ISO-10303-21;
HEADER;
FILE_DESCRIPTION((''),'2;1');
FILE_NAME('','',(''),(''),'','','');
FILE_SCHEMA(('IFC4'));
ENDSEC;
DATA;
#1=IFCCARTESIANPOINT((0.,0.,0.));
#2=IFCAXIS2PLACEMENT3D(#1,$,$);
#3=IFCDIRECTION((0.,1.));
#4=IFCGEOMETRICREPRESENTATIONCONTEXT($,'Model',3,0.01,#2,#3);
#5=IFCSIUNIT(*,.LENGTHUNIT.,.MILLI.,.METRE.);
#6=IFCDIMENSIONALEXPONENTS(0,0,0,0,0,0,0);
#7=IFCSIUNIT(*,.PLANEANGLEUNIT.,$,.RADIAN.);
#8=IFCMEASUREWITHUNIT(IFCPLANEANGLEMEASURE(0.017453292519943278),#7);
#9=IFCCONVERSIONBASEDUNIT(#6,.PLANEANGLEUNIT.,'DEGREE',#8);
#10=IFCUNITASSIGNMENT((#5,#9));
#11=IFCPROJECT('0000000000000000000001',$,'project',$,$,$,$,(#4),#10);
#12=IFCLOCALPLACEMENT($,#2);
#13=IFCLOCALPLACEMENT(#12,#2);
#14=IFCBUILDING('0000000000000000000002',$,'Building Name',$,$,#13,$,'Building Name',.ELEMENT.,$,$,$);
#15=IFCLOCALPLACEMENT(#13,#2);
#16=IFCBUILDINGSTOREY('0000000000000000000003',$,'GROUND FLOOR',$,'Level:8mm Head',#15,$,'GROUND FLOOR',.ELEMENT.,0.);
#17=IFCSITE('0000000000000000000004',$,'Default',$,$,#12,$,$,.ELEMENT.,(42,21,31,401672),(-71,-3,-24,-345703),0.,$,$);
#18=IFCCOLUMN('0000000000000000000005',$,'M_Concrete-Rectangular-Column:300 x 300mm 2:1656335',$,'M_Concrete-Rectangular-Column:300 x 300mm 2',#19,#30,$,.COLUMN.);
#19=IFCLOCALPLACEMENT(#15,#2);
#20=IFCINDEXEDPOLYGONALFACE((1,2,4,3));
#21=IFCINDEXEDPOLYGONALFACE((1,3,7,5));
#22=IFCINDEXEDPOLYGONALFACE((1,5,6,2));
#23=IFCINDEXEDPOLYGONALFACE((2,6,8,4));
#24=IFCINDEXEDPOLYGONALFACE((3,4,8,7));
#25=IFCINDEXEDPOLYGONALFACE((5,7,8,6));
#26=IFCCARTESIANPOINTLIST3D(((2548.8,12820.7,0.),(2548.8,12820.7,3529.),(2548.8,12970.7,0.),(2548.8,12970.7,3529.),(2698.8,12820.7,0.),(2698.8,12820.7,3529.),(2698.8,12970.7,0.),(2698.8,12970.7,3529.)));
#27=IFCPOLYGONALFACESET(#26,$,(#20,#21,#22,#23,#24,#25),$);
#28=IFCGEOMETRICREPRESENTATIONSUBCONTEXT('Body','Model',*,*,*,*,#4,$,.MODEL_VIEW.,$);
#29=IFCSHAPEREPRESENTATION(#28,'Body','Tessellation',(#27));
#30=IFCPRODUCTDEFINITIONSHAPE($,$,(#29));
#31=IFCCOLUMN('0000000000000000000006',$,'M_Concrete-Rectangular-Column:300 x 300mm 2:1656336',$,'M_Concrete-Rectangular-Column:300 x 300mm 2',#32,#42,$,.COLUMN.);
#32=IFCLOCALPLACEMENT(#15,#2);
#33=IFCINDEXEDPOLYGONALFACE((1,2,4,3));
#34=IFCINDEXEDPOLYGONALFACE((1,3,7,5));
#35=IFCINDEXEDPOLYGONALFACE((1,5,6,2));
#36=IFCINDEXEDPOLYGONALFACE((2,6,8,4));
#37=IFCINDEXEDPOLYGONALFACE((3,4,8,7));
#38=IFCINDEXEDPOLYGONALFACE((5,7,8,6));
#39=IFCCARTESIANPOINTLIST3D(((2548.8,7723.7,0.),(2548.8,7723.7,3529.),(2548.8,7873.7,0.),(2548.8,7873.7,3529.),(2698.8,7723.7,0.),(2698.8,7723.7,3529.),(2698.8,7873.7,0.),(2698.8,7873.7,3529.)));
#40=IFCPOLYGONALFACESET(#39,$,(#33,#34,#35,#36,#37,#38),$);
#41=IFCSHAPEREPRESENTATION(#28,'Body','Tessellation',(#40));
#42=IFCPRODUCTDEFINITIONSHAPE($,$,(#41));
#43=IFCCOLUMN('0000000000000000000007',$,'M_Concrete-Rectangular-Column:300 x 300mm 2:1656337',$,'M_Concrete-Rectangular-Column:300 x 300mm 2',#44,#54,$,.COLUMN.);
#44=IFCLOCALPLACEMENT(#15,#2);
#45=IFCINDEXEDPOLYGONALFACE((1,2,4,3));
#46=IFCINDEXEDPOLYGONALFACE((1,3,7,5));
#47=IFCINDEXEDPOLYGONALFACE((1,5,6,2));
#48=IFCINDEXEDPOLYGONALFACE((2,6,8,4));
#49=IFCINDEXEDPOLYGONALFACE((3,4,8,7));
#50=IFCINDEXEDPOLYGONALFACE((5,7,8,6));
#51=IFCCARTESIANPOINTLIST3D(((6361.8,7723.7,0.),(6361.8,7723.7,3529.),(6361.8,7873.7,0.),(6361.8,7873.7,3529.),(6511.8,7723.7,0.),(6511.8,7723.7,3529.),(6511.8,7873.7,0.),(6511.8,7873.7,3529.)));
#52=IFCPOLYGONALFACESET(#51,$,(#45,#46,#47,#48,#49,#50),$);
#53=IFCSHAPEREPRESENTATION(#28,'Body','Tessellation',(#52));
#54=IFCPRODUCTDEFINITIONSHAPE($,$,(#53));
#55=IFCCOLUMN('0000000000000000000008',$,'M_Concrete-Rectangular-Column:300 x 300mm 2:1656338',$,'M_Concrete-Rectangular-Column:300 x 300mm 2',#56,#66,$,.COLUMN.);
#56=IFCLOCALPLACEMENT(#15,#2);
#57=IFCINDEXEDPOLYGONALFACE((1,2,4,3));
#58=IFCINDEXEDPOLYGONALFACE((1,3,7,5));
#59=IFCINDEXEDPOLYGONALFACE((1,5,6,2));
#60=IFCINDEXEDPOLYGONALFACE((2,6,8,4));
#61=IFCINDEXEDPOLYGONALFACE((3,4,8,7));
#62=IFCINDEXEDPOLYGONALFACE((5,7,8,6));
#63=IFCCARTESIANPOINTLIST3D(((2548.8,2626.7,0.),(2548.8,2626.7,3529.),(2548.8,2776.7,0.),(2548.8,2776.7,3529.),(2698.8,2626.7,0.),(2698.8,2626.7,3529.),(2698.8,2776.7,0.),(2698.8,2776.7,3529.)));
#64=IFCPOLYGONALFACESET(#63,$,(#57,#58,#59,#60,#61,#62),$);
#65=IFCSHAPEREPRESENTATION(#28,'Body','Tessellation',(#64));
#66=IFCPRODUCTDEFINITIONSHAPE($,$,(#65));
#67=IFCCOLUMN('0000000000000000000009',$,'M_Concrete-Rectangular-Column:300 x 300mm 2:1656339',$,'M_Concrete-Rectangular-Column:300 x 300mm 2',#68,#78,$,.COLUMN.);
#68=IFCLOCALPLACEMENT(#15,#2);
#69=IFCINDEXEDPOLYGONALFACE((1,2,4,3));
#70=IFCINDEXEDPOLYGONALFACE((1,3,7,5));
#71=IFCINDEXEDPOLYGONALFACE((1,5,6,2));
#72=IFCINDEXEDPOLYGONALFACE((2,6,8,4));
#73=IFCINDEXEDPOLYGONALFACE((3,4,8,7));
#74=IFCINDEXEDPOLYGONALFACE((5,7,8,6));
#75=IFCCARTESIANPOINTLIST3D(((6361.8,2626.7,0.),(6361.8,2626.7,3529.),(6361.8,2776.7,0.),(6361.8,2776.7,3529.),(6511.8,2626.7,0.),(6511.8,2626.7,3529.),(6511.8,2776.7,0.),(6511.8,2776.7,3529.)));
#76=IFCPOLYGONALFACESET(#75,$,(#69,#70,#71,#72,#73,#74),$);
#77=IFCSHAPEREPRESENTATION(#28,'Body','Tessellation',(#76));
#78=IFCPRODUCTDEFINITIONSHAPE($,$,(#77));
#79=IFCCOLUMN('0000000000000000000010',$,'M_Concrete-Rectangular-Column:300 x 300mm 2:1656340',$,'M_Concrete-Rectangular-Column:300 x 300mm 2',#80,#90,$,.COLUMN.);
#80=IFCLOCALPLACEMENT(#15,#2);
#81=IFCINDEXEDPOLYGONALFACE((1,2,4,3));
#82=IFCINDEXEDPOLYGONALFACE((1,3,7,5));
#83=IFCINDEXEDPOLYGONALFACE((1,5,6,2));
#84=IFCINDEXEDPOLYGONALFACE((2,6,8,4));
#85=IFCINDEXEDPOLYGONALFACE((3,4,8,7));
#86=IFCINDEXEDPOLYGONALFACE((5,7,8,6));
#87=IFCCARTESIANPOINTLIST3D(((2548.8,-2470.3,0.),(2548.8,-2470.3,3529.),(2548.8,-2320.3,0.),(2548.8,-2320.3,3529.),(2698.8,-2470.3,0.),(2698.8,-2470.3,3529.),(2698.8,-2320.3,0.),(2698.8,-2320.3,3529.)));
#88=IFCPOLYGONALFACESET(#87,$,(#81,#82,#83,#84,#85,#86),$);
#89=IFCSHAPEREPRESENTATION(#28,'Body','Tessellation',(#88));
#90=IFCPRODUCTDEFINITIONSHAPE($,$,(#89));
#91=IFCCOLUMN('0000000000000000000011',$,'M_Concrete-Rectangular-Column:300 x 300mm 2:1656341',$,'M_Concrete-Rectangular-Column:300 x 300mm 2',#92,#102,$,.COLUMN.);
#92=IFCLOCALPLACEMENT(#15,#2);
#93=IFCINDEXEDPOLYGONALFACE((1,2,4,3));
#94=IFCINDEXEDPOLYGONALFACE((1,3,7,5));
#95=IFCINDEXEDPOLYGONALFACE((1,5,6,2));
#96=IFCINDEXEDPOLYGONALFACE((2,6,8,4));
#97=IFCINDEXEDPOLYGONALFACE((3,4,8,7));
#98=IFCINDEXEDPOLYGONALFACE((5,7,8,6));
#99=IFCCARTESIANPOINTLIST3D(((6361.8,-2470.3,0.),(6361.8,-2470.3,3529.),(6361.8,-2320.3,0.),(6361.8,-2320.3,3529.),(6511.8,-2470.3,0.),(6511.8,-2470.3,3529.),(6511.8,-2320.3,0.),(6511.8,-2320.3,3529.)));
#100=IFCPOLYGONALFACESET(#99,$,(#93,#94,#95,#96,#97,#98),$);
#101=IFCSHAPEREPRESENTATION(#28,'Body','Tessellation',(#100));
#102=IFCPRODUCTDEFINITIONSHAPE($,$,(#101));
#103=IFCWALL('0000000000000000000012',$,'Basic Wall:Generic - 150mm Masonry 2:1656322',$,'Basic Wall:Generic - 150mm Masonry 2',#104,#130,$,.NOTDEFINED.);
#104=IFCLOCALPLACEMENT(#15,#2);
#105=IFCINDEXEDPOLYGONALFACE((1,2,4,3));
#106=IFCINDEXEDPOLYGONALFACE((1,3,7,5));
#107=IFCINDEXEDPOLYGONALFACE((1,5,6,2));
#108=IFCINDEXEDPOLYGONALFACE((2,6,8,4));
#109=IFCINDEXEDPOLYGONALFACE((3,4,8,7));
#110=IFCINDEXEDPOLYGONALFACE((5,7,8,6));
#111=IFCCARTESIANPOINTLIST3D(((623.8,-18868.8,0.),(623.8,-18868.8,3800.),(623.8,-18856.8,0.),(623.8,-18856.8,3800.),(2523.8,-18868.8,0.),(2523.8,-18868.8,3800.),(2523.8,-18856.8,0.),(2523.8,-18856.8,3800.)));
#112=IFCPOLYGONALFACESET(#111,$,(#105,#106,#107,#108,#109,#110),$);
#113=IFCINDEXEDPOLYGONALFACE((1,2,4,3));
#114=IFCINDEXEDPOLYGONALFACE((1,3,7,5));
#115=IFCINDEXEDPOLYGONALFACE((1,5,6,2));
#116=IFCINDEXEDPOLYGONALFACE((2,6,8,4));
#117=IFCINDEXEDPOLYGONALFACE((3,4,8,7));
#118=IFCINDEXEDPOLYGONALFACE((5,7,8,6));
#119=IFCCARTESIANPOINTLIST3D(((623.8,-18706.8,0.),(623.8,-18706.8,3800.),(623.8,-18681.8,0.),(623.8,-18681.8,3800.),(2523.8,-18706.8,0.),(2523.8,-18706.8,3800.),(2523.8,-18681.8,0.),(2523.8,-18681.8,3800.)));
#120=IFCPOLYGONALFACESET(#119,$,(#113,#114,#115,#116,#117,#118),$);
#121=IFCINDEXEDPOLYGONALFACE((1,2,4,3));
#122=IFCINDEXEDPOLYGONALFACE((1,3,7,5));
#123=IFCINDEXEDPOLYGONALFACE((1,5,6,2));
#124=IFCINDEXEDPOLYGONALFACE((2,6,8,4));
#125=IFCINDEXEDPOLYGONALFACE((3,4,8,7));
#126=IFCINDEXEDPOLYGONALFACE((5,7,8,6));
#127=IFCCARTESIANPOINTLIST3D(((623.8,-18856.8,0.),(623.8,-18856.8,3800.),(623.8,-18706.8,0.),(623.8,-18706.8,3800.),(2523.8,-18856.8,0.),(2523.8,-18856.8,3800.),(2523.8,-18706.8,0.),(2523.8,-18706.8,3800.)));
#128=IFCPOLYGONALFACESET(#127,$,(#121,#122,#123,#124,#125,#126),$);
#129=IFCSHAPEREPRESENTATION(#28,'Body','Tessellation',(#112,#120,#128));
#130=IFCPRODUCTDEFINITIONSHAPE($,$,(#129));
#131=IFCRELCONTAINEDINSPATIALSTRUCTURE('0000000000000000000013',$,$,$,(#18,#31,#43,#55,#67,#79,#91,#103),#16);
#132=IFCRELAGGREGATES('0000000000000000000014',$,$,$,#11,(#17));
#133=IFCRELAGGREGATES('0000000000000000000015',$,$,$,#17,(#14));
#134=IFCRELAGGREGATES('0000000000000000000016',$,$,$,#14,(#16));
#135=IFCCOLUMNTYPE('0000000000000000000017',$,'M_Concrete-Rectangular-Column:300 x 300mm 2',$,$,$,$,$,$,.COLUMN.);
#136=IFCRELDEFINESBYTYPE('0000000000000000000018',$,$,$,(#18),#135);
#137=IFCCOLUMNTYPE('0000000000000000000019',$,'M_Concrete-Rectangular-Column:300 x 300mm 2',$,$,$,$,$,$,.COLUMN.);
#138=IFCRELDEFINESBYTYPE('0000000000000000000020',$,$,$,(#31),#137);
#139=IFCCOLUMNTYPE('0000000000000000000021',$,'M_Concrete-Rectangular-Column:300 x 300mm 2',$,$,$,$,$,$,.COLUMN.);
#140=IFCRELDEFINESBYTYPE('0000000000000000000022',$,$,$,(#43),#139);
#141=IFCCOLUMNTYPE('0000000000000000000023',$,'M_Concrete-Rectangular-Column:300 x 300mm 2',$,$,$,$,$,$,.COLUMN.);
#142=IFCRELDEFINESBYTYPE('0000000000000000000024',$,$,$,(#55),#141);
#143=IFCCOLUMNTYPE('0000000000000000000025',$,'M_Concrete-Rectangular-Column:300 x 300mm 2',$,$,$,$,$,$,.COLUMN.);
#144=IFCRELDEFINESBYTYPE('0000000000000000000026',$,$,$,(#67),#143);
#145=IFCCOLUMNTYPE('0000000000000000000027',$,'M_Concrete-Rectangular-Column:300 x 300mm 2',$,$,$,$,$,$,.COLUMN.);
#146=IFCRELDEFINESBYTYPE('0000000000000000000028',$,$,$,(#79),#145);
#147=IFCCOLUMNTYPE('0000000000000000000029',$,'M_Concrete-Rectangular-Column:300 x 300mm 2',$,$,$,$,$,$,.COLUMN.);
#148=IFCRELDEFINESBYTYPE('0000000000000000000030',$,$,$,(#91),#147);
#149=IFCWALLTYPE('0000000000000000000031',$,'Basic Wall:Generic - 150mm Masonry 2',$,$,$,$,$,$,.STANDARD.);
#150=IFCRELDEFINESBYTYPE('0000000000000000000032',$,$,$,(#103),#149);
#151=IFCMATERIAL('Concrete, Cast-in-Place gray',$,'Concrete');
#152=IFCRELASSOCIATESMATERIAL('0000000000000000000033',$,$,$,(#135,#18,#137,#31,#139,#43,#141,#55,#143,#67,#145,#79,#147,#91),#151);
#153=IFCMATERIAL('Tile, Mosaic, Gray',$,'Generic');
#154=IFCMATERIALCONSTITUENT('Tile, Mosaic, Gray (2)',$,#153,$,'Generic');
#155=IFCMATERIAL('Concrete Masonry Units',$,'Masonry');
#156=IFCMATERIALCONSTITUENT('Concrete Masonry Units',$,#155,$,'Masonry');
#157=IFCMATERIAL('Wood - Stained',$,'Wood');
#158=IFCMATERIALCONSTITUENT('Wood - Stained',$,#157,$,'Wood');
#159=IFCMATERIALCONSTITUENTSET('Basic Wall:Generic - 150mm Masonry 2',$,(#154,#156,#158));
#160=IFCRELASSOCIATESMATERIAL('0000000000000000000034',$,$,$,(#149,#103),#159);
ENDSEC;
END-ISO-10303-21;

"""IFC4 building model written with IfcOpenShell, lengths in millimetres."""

from ifc_helpers import new_model, entity, si_unit, converted_unit, direction, frame, origin, place, context, subcontext, project, spatial, indexed_curve, outline, extrude, source, transform, mapped, material, constituent, constituent_set, type_object, type_shapes, element, save


model = new_model("IFC4")

# Units and contexts
model_context = context("Model", 3, precision=0.01, world=origin(), true_north=direction((0.0, 1.0)))
body_context = subcontext(model_context, "Body", "Model", "MODEL_VIEW")
ifc_project = project(units=[si_unit("LENGTHUNIT", "METRE", prefix="MILLI"), converted_unit("PLANEANGLEUNIT", "DEGREE", entity("IfcPlaneAngleMeasure", 0.017453292519943278), si_unit("PLANEANGLEUNIT", "RADIAN"), dimensions=[0, 0, 0, 0, 0, 0, 0])], contexts=[model_context])

# Site, building, storey
site_placement = place(None, origin())
site = spatial("IfcSite", under=ifc_project, at=site_placement, Name="Default", CompositionType="ELEMENT", RefLatitude=(42, 21, 31, 401672), RefLongitude=(-71, -3, -24, -345703), RefElevation=0.0)
building_placement = place(site_placement, origin())
building = spatial("IfcBuilding", under=site, at=building_placement, Name="Building Name", LongName="Building Name", CompositionType="ELEMENT")
storey_placement = place(building_placement, origin())
storey = spatial("IfcBuildingStorey", under=building, at=storey_placement, Name="GROUND FLOOR", ObjectType="Level:8mm Head", LongName="GROUND FLOOR", CompositionType="ELEMENT", Elevation=0.0)

# Columns
ifc_material_1 = material(Name="Concrete, Cast-in-Place gray", Category="Concrete")
column_type_1 = type_object("IfcColumnType", Name="M_Concrete-Rectangular-Column:300 x 300mm 2", PredefinedType="COLUMN", material=ifc_material_1)
shared_shape_1 = source(origin(), body_context, "Body", "SweptSolid", [
    extrude(outline(indexed_curve([(-75.0, -75.0), (75.0, -75.0), (75.0, 75.0), (-75.0, 75.0), (-75.0, -75.0)], self_intersect=False)), frame((2623.8, 12895.7, 0.0)), (0.0, 0.0, 1.0), 3529.0),
])
type_shapes(column_type_1, [shared_shape_1])
column_1_placement = place(storey_placement, origin())
element("IfcColumn", 1, at=column_1_placement, inside=storey, type_object=column_type_1, material=ifc_material_1, Name="M_Concrete-Rectangular-Column:300 x 300mm 2:1656335", ObjectType="M_Concrete-Rectangular-Column:300 x 300mm 2", PredefinedType="COLUMN", context=body_context, shape_type="MappedRepresentation", body=[
    mapped(shared_shape_1, transform((0.0, 0.0, 0.0), scale=1.0)),
])
column_type_2 = type_object("IfcColumnType", Name="M_Concrete-Rectangular-Column:300 x 300mm 2", PredefinedType="COLUMN", material=ifc_material_1)
shared_shape_2 = source(origin(), body_context, "Body", "SweptSolid", [
    extrude(outline(indexed_curve([(-75.0, -75.0), (75.0, -75.0), (75.0, 75.0), (-75.0, 75.0), (-75.0, -75.0)], self_intersect=False)), frame((2623.8, 7798.7, 0.0)), (0.0, 0.0, 1.0), 3529.0),
])
type_shapes(column_type_2, [shared_shape_2])
column_2_placement = place(storey_placement, origin())
element("IfcColumn", 2, at=column_2_placement, inside=storey, type_object=column_type_2, material=ifc_material_1, Name="M_Concrete-Rectangular-Column:300 x 300mm 2:1656336", ObjectType="M_Concrete-Rectangular-Column:300 x 300mm 2", PredefinedType="COLUMN", context=body_context, shape_type="MappedRepresentation", body=[
    mapped(shared_shape_2, transform((0.0, 0.0, 0.0), scale=1.0)),
])
column_type_3 = type_object("IfcColumnType", Name="M_Concrete-Rectangular-Column:300 x 300mm 2", PredefinedType="COLUMN", material=ifc_material_1)
shared_shape_3 = source(origin(), body_context, "Body", "SweptSolid", [
    extrude(outline(indexed_curve([(-75.0, -75.0), (75.0, -75.0), (75.0, 75.0), (-75.0, 75.0), (-75.0, -75.0)], self_intersect=False)), frame((6436.8, 7798.7, 0.0)), (0.0, 0.0, 1.0), 3529.0),
])
type_shapes(column_type_3, [shared_shape_3])
column_3_placement = place(storey_placement, origin())
element("IfcColumn", 3, at=column_3_placement, inside=storey, type_object=column_type_3, material=ifc_material_1, Name="M_Concrete-Rectangular-Column:300 x 300mm 2:1656337", ObjectType="M_Concrete-Rectangular-Column:300 x 300mm 2", PredefinedType="COLUMN", context=body_context, shape_type="MappedRepresentation", body=[
    mapped(shared_shape_3, transform((0.0, 0.0, 0.0), scale=1.0)),
])
column_type_4 = type_object("IfcColumnType", Name="M_Concrete-Rectangular-Column:300 x 300mm 2", PredefinedType="COLUMN", material=ifc_material_1)
shared_shape_4 = source(origin(), body_context, "Body", "SweptSolid", [
    extrude(outline(indexed_curve([(-75.0, -75.0), (75.0, -75.0), (75.0, 75.0), (-75.0, 75.0), (-75.0, -75.0)], self_intersect=False)), frame((2623.8, 2701.7, 0.0)), (0.0, 0.0, 1.0), 3529.0),
])
type_shapes(column_type_4, [shared_shape_4])
column_4_placement = place(storey_placement, origin())
element("IfcColumn", 4, at=column_4_placement, inside=storey, type_object=column_type_4, material=ifc_material_1, Name="M_Concrete-Rectangular-Column:300 x 300mm 2:1656338", ObjectType="M_Concrete-Rectangular-Column:300 x 300mm 2", PredefinedType="COLUMN", context=body_context, shape_type="MappedRepresentation", body=[
    mapped(shared_shape_4, transform((0.0, 0.0, 0.0), scale=1.0)),
])
column_type_5 = type_object("IfcColumnType", Name="M_Concrete-Rectangular-Column:300 x 300mm 2", PredefinedType="COLUMN", material=ifc_material_1)
shared_shape_5 = source(origin(), body_context, "Body", "SweptSolid", [
    extrude(outline(indexed_curve([(-75.0, -75.0), (75.0, -75.0), (75.0, 75.0), (-75.0, 75.0), (-75.0, -75.0)], self_intersect=False)), frame((6436.8, 2701.7, 0.0)), (0.0, 0.0, 1.0), 3529.0),
])
type_shapes(column_type_5, [shared_shape_5])
column_5_placement = place(storey_placement, origin())
element("IfcColumn", 5, at=column_5_placement, inside=storey, type_object=column_type_5, material=ifc_material_1, Name="M_Concrete-Rectangular-Column:300 x 300mm 2:1656339", ObjectType="M_Concrete-Rectangular-Column:300 x 300mm 2", PredefinedType="COLUMN", context=body_context, shape_type="MappedRepresentation", body=[
    mapped(shared_shape_5, transform((0.0, 0.0, 0.0), scale=1.0)),
])
column_type_6 = type_object("IfcColumnType", Name="M_Concrete-Rectangular-Column:300 x 300mm 2", PredefinedType="COLUMN", material=ifc_material_1)
shared_shape_6 = source(origin(), body_context, "Body", "SweptSolid", [
    extrude(outline(indexed_curve([(-75.0, -75.0), (75.0, -75.0), (75.0, 75.0), (-75.0, 75.0), (-75.0, -75.0)], self_intersect=False)), frame((2623.8, -2395.3, 0.0)), (0.0, 0.0, 1.0), 3529.0),
])
type_shapes(column_type_6, [shared_shape_6])
column_6_placement = place(storey_placement, origin())
element("IfcColumn", 6, at=column_6_placement, inside=storey, type_object=column_type_6, material=ifc_material_1, Name="M_Concrete-Rectangular-Column:300 x 300mm 2:1656340", ObjectType="M_Concrete-Rectangular-Column:300 x 300mm 2", PredefinedType="COLUMN", context=body_context, shape_type="MappedRepresentation", body=[
    mapped(shared_shape_6, transform((0.0, 0.0, 0.0), scale=1.0)),
])
column_type_7 = type_object("IfcColumnType", Name="M_Concrete-Rectangular-Column:300 x 300mm 2", PredefinedType="COLUMN", material=ifc_material_1)
shared_shape_7 = source(origin(), body_context, "Body", "SweptSolid", [
    extrude(outline(indexed_curve([(-75.0, -75.0), (75.0, -75.0), (75.0, 75.0), (-75.0, 75.0), (-75.0, -75.0)], self_intersect=False)), frame((6436.8, -2395.3, 0.0)), (0.0, 0.0, 1.0), 3529.0),
])
type_shapes(column_type_7, [shared_shape_7])
column_7_placement = place(storey_placement, origin())
element("IfcColumn", 7, at=column_7_placement, inside=storey, type_object=column_type_7, material=ifc_material_1, Name="M_Concrete-Rectangular-Column:300 x 300mm 2:1656341", ObjectType="M_Concrete-Rectangular-Column:300 x 300mm 2", PredefinedType="COLUMN", context=body_context, shape_type="MappedRepresentation", body=[
    mapped(shared_shape_7, transform((0.0, 0.0, 0.0), scale=1.0)),
])

# Wall
ifc_material_2 = material(Name="Tile, Mosaic, Gray", Category="Generic")
ifc_constituent_1 = constituent(ifc_material_2, Name="Tile, Mosaic, Gray (2)", Category="Generic")
ifc_material_3 = material(Name="Concrete Masonry Units", Category="Masonry")
ifc_constituent_2 = constituent(ifc_material_3, Name="Concrete Masonry Units", Category="Masonry")
ifc_material_4 = material(Name="Wood - Stained", Category="Wood")
ifc_constituent_3 = constituent(ifc_material_4, Name="Wood - Stained", Category="Wood")
ifc_constituent_set_1 = constituent_set(constituents=[ifc_constituent_1, ifc_constituent_2, ifc_constituent_3], Name="Basic Wall:Generic - 150mm Masonry 2")
wall_type_1 = type_object("IfcWallType", Name="Basic Wall:Generic - 150mm Masonry 2", PredefinedType="STANDARD", material=ifc_constituent_set_1)
wall_1_placement = place(storey_placement, frame((2523.8, -18775.3, 0.0), z_axis=(0.0, 0.0, 1.0), x_axis=(-1.0, 0.0, 0.0)))
element("IfcWall", 8, at=wall_1_placement, inside=storey, type_object=wall_type_1, material=ifc_constituent_set_1, Name="Basic Wall:Generic - 150mm Masonry 2:1656322", ObjectType="Basic Wall:Generic - 150mm Masonry 2", PredefinedType="NOTDEFINED", context=body_context, shape_type="SweptSolid", body=[
    extrude(outline(indexed_curve([(-6.0, -950.0), (6.0, -950.0), (6.0, 950.0), (-6.0, 950.0), (-6.0, -950.0)], self_intersect=False)), frame((950.0, 87.5, 0.0), z_axis=(0.0, 0.0, 1.0), x_axis=(0.0, -1.0, 0.0)), (0.0, 0.0, 1.0), 3800.0),
    extrude(outline(indexed_curve([(-12.5, -950.0), (12.5, -950.0), (12.5, 950.0), (-12.5, 950.0), (-12.5, -950.0)], self_intersect=False)), frame((950.0, -81.0, 0.0), z_axis=(0.0, 0.0, 1.0), x_axis=(0.0, 1.0, 0.0)), (0.0, 0.0, 1.0), 3800.0),
    extrude(outline(indexed_curve([(-950.0, -75.0), (950.0, -75.0), (950.0, 75.0), (-950.0, 75.0), (-950.0, -75.0)], self_intersect=False)), frame((950.0, 6.5, 0.0)), (0.0, 0.0, 1.0), 3800.0),
])

save(model, "model.ifc")
